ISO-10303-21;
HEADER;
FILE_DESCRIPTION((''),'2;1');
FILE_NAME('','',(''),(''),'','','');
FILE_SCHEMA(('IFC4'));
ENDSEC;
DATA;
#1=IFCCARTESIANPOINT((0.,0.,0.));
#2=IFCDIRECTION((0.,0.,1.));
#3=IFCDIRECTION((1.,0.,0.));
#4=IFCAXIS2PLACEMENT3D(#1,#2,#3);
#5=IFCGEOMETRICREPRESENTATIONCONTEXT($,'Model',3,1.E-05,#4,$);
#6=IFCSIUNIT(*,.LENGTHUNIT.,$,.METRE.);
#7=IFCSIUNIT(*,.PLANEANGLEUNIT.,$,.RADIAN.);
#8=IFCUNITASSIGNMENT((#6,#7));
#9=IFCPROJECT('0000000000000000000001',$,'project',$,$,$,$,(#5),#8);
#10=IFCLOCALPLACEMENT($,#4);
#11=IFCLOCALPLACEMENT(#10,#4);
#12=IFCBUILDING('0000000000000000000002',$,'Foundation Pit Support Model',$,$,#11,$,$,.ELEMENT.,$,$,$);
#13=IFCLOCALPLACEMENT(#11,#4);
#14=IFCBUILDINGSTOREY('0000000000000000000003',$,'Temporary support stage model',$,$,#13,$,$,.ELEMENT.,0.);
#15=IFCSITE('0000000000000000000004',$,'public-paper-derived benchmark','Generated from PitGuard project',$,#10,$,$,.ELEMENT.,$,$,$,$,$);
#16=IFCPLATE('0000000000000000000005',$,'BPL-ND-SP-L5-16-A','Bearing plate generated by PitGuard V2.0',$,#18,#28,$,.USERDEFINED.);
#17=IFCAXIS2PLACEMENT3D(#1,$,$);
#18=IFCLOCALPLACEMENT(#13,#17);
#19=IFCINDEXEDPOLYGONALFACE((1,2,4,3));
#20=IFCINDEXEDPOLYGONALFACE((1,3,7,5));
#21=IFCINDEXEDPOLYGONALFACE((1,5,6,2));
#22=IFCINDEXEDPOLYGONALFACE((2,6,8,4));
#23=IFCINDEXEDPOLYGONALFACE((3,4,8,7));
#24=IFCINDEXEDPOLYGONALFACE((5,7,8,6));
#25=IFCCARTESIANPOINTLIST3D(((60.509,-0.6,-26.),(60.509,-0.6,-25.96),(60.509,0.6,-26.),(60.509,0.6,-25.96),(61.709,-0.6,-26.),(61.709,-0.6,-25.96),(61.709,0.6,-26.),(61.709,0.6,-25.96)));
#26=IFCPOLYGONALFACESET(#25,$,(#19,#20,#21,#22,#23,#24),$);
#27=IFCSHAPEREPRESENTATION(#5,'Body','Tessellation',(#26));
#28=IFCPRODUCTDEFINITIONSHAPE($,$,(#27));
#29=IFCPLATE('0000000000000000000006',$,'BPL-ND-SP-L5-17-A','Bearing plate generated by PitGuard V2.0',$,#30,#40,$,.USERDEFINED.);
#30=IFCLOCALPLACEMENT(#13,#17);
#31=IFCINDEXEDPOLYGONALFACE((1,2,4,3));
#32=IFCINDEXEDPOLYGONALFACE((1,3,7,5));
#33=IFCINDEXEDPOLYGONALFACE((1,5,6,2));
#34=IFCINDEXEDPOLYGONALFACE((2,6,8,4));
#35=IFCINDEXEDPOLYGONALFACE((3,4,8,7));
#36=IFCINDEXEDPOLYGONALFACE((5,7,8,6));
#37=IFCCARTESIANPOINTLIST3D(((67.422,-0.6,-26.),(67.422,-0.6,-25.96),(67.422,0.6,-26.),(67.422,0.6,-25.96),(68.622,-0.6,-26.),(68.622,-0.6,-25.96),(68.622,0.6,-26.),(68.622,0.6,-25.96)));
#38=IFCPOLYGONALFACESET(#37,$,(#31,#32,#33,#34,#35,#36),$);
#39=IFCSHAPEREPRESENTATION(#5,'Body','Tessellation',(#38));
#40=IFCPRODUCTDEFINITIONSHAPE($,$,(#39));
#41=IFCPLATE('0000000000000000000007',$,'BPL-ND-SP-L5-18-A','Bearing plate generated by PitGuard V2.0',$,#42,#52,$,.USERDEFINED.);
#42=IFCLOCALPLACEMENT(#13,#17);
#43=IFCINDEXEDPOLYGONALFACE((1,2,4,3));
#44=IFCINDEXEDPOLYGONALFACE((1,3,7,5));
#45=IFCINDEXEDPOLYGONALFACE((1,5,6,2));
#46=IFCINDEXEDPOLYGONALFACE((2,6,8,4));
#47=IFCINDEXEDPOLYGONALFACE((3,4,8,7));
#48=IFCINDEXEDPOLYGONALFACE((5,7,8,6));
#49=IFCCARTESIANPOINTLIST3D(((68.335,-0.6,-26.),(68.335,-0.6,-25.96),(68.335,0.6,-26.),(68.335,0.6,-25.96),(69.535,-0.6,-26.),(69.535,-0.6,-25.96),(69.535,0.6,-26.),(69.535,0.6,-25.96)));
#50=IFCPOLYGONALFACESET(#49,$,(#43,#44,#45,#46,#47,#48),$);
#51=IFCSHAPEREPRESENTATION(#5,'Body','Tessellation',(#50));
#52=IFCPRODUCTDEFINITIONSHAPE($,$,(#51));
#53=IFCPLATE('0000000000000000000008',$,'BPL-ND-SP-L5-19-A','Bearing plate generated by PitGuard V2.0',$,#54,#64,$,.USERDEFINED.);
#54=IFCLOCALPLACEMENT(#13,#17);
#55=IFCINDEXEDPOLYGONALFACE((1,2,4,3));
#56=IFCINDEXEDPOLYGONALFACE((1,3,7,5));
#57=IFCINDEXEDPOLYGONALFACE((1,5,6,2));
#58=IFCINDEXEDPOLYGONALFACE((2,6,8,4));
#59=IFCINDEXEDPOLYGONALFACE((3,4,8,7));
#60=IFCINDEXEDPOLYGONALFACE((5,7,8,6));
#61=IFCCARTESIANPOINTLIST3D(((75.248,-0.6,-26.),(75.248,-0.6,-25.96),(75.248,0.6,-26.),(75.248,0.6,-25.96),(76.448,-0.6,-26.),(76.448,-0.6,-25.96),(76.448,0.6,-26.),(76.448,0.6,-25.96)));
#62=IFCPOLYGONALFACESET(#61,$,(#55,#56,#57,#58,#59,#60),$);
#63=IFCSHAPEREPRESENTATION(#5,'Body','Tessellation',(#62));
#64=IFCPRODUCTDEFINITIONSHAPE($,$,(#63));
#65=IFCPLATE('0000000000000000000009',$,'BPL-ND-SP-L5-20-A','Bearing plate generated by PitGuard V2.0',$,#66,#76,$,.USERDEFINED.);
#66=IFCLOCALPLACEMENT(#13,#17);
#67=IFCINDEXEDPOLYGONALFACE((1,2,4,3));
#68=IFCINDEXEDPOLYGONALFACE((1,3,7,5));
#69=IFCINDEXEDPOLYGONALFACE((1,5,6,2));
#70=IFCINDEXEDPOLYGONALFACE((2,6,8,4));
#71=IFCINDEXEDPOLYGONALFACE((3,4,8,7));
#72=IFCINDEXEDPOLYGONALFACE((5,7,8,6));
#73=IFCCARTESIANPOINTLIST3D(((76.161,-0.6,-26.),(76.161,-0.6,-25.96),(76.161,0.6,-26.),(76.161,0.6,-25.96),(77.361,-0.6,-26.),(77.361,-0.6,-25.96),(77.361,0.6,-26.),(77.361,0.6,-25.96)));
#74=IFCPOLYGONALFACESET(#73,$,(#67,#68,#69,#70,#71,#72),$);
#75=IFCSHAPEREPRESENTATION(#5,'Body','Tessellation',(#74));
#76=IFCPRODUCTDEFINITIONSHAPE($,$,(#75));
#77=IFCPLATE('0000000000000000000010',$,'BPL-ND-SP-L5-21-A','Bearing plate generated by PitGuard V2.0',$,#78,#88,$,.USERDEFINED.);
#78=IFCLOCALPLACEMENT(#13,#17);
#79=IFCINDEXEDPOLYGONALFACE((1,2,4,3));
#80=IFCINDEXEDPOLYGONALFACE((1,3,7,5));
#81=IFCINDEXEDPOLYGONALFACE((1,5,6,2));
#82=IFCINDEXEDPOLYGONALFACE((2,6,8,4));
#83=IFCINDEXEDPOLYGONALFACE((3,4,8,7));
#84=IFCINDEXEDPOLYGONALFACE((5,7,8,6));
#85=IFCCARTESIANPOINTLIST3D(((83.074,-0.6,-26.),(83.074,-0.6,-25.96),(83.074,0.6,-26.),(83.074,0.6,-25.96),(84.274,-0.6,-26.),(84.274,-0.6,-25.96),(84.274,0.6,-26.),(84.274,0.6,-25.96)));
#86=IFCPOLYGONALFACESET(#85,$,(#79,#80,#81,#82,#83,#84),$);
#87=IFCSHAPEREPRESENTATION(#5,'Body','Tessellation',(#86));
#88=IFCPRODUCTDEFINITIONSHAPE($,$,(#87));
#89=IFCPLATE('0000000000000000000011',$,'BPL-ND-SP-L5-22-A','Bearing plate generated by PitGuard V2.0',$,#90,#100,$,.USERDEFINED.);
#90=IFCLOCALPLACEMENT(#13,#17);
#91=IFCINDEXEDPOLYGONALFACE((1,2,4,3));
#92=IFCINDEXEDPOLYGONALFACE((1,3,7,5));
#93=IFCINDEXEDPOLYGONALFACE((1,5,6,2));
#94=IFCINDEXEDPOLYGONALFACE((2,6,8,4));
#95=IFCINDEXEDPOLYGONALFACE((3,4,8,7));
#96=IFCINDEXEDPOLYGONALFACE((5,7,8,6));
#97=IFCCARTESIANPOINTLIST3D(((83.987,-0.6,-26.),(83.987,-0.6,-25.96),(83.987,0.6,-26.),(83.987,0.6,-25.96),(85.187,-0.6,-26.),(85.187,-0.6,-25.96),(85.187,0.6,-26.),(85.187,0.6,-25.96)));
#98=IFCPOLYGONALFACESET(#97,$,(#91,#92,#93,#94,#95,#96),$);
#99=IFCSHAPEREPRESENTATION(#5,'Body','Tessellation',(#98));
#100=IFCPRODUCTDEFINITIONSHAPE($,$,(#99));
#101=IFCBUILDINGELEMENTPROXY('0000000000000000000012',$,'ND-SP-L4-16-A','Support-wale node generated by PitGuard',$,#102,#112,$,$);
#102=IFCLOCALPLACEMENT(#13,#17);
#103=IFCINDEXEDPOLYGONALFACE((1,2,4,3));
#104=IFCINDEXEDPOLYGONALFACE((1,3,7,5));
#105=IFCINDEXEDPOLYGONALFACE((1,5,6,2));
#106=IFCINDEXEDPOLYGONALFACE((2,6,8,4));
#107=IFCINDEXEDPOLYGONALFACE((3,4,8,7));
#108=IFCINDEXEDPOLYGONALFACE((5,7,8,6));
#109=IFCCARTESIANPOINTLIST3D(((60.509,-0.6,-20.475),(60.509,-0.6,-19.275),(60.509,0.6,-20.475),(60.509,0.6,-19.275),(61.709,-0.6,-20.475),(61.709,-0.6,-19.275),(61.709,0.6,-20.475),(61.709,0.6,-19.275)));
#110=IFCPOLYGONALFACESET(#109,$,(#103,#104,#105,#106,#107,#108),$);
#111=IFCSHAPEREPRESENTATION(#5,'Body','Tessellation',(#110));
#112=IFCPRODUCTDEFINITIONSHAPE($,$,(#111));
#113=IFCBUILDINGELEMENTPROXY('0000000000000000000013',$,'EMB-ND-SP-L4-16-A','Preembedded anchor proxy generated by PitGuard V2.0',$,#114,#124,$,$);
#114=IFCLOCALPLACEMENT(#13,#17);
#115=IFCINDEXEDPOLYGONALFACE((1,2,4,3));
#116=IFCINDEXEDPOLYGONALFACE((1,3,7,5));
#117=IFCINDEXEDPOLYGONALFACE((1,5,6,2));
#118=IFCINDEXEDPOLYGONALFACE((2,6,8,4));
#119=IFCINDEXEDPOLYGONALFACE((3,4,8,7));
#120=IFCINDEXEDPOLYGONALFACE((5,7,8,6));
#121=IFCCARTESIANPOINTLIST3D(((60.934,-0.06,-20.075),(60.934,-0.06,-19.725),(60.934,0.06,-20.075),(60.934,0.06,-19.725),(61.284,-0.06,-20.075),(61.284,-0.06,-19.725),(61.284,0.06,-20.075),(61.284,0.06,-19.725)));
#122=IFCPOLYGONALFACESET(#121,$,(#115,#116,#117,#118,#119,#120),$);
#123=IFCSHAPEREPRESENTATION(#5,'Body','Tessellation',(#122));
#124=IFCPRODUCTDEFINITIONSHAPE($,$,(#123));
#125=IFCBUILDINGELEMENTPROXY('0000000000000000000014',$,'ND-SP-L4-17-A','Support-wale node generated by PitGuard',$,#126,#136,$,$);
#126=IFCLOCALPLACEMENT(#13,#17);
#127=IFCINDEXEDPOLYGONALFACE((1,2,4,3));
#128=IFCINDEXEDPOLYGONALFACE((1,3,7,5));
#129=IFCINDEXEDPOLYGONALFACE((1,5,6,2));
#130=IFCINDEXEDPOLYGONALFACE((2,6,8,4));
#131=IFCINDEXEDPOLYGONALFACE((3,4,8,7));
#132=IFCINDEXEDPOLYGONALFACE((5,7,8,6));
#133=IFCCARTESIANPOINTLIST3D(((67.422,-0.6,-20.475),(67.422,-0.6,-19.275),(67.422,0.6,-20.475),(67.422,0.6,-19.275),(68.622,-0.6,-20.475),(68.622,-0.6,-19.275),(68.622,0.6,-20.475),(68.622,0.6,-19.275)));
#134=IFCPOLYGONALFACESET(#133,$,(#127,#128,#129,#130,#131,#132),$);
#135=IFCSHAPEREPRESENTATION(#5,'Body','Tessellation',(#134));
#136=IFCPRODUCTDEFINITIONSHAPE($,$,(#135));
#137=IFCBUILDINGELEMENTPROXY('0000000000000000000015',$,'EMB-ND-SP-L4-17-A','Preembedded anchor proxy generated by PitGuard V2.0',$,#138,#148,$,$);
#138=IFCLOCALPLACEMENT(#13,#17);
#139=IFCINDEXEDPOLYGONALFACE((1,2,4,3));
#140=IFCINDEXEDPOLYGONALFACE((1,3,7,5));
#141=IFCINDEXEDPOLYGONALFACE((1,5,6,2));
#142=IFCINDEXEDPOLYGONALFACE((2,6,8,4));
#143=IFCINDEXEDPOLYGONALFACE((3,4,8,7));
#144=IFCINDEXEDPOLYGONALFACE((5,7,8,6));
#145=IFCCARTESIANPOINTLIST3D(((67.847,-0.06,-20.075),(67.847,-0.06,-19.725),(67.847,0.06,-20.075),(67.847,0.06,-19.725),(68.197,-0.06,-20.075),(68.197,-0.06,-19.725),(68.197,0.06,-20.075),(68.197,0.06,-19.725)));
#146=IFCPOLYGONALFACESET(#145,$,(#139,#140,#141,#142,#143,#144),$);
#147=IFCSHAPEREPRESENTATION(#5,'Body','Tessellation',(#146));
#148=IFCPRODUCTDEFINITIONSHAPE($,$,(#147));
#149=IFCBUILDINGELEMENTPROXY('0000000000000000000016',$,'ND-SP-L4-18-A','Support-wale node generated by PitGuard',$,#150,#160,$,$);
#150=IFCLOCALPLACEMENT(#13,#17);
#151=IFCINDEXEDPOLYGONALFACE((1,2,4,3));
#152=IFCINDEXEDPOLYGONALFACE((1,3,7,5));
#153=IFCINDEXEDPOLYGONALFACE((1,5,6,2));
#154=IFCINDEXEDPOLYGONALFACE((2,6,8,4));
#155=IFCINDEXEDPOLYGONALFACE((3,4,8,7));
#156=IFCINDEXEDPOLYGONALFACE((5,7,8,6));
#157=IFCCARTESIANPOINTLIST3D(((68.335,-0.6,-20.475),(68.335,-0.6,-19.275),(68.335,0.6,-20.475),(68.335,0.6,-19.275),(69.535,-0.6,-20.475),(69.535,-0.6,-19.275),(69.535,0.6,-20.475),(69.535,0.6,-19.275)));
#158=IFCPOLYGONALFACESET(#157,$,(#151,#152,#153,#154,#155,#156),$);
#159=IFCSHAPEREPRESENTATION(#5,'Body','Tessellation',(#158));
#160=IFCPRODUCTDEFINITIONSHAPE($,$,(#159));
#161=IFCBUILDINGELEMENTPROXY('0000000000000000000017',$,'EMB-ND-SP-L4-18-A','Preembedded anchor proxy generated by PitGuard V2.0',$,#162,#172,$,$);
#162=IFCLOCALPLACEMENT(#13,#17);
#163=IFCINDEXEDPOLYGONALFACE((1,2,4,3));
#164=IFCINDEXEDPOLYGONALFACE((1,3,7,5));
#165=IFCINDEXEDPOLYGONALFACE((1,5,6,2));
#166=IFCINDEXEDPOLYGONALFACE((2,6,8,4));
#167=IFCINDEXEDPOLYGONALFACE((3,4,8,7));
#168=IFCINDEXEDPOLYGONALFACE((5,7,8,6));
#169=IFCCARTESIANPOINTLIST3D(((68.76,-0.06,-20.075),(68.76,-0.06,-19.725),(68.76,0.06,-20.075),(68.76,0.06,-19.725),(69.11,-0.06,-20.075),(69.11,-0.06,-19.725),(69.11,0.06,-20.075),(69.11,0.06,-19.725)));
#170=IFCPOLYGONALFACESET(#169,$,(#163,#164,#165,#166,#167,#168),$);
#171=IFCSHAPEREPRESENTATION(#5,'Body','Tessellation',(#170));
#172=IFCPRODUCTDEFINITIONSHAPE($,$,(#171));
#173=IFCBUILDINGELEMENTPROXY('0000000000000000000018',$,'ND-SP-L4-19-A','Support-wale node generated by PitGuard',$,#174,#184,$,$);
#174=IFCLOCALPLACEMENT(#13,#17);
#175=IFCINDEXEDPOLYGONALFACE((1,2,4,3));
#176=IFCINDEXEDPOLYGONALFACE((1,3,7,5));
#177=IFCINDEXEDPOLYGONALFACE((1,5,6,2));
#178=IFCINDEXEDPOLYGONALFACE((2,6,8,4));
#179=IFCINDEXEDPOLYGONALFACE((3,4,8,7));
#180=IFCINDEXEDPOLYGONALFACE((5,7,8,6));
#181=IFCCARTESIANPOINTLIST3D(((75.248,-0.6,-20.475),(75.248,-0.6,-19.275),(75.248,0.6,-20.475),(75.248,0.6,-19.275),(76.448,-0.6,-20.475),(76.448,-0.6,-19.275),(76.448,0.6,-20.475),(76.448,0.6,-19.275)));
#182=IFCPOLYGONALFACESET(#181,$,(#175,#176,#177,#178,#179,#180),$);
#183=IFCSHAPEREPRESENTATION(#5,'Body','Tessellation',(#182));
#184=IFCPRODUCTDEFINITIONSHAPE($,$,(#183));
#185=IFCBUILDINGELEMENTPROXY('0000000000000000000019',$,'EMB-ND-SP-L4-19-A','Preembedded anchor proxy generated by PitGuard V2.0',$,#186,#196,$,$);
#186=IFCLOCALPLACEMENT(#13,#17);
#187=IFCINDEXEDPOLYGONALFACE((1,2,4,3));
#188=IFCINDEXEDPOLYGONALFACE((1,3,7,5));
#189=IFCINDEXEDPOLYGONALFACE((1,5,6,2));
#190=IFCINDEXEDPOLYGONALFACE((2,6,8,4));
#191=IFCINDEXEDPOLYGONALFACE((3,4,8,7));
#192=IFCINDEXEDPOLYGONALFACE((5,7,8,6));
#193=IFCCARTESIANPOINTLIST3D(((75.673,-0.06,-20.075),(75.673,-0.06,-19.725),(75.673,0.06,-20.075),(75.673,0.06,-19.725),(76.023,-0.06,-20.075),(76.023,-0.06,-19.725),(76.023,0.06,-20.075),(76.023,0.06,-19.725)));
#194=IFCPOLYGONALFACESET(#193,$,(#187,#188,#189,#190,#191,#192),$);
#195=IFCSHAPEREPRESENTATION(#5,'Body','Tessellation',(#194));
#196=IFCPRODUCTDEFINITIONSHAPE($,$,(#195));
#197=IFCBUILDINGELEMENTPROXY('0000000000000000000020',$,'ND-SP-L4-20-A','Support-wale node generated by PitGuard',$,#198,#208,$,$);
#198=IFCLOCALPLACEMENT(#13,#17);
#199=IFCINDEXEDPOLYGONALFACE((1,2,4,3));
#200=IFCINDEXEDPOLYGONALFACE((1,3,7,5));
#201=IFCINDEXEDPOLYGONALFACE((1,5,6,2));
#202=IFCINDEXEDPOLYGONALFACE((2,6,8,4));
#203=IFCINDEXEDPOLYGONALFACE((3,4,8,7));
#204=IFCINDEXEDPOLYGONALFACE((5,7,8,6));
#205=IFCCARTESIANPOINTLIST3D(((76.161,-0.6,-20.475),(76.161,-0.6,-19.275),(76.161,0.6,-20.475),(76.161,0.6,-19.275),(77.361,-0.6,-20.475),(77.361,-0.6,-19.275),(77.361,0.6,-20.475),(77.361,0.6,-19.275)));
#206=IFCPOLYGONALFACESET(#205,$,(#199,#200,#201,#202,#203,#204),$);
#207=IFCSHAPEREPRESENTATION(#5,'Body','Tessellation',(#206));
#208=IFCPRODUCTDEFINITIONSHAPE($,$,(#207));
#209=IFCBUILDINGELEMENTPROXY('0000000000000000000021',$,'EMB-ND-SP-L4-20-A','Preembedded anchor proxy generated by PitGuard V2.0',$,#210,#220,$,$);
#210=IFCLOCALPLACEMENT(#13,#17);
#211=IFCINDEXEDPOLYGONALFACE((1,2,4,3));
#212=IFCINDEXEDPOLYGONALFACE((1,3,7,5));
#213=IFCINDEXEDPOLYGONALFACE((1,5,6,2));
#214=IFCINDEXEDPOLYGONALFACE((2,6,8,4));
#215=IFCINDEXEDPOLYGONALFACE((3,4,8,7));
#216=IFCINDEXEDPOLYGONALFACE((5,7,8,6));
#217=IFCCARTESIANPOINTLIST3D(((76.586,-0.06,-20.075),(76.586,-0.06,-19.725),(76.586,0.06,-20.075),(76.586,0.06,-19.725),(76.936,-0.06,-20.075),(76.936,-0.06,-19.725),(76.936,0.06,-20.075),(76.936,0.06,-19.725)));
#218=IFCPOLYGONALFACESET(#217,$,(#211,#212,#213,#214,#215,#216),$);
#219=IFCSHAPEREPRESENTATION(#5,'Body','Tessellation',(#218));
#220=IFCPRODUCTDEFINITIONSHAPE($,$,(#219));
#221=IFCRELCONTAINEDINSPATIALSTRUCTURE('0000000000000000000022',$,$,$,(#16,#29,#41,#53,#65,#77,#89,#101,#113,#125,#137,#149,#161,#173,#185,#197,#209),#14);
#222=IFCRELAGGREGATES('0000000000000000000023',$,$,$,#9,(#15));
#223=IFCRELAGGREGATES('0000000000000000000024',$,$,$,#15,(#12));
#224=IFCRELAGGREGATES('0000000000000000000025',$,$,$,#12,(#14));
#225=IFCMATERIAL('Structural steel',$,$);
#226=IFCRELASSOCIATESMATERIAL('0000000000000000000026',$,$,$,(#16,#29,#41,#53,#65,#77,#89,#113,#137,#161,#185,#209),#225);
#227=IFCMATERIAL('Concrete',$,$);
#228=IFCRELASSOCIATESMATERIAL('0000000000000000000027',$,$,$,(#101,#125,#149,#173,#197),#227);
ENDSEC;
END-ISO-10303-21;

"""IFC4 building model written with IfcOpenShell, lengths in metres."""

from ifc_helpers import new_model, si_unit, frame, origin_with_axes, origin_2d, place, context, project, spatial, rectangle, extrude, material, element, save


model = new_model("IFC4")

# Units and contexts
model_context = context("Model", 3, precision=1e-05, world=origin_with_axes())
ifc_project = project(units=[si_unit("LENGTHUNIT", "METRE"), si_unit("PLANEANGLEUNIT", "RADIAN")], contexts=[model_context])

# Site, building, storey
site_placement = place(None, origin_with_axes())
site = spatial("IfcSite", under=ifc_project, at=site_placement, Name="public-paper-derived benchmark", Description="Generated from PitGuard project", CompositionType="ELEMENT")
building_placement = place(site_placement, origin_with_axes())
building = spatial("IfcBuilding", under=site, at=building_placement, Name="Foundation Pit Support Model", CompositionType="ELEMENT")
storey_placement = place(building_placement, origin_with_axes())
storey = spatial("IfcBuildingStorey", under=building, at=storey_placement, Name="Temporary support stage model", CompositionType="ELEMENT", Elevation=0.0)

# Plates
ifc_material_1 = material(Name="Structural steel")
for number, where, z_axis, x_axis, name in (
    (1, (61.109, 0.0, -26.0), (0.0, 0.0, 1.0), (1.0, 0.0, 0.0), "BPL-ND-SP-L5-16-A"),
    (2, (68.022, 0.0, -26.0), (0.0, 0.0, 1.0), (1.0, 0.0, 0.0), "BPL-ND-SP-L5-17-A"),
    (3, (68.935, 0.0, -26.0), (0.0, 0.0, 1.0), (1.0, 0.0, 0.0), "BPL-ND-SP-L5-18-A"),
    (4, (75.848, 0.0, -26.0), (0.0, 0.0, 1.0), (1.0, 0.0, 0.0), "BPL-ND-SP-L5-19-A"),
    (5, (76.761, 0.0, -26.0), (0.0, 0.0, 1.0), (1.0, 0.0, 0.0), "BPL-ND-SP-L5-20-A"),
    (6, (83.674, 0.0, -26.0), (0.0, 0.0, 1.0), (1.0, 0.0, 0.0), "BPL-ND-SP-L5-21-A"),
    (7, (84.587, 0.0, -26.0), (0.0, 0.0, 1.0), (1.0, 0.0, 0.0), "BPL-ND-SP-L5-22-A"),
):
    element("IfcPlate", number, at=place(storey_placement, frame(where, z_axis=z_axis, x_axis=x_axis)), inside=storey, material=ifc_material_1, Name=name, Description="Bearing plate generated by PitGuard V2.0", PredefinedType="USERDEFINED", context=model_context, shape_type="SweptSolid", body=[
        extrude(rectangle(XDim=1.2, YDim=1.2, at=origin_2d()), origin_with_axes(), (0.0, 0.0, 1.0), 0.04),
    ])

# Building element proxies
ifc_material_2 = material(Name="Concrete")
proxy_1_placement = place(storey_placement, frame((61.109, 0.0, -20.475), z_axis=(0.0, 0.0, 1.0), x_axis=(1.0, 0.0, 0.0)))
element("IfcBuildingElementProxy", 8, at=proxy_1_placement, inside=storey, material=ifc_material_2, Name="ND-SP-L4-16-A", Description="Support-wale node generated by PitGuard", context=model_context, shape_type="SweptSolid", body=[
    extrude(rectangle(XDim=1.2, YDim=1.2, at=origin_2d()), origin_with_axes(), (0.0, 0.0, 1.0), 1.2),
])
proxy_2_placement = place(storey_placement, frame((61.109, 0.0, -20.075), z_axis=(0.0, 0.0, 1.0), x_axis=(1.0, 0.0, 0.0)))
element("IfcBuildingElementProxy", 9, at=proxy_2_placement, inside=storey, material=ifc_material_1, Name="EMB-ND-SP-L4-16-A", Description="Preembedded anchor proxy generated by PitGuard V2.0", context=model_context, shape_type="SweptSolid", body=[
    extrude(rectangle(XDim=0.35, YDim=0.12, at=origin_2d()), origin_with_axes(), (0.0, 0.0, 1.0), 0.35),
])
proxy_3_placement = place(storey_placement, frame((68.022, 0.0, -20.475), z_axis=(0.0, 0.0, 1.0), x_axis=(1.0, 0.0, 0.0)))
element("IfcBuildingElementProxy", 10, at=proxy_3_placement, inside=storey, material=ifc_material_2, Name="ND-SP-L4-17-A", Description="Support-wale node generated by PitGuard", context=model_context, shape_type="SweptSolid", body=[
    extrude(rectangle(XDim=1.2, YDim=1.2, at=origin_2d()), origin_with_axes(), (0.0, 0.0, 1.0), 1.2),
])
proxy_4_placement = place(storey_placement, frame((68.022, 0.0, -20.075), z_axis=(0.0, 0.0, 1.0), x_axis=(1.0, 0.0, 0.0)))
element("IfcBuildingElementProxy", 11, at=proxy_4_placement, inside=storey, material=ifc_material_1, Name="EMB-ND-SP-L4-17-A", Description="Preembedded anchor proxy generated by PitGuard V2.0", context=model_context, shape_type="SweptSolid", body=[
    extrude(rectangle(XDim=0.35, YDim=0.12, at=origin_2d()), origin_with_axes(), (0.0, 0.0, 1.0), 0.35),
])
proxy_5_placement = place(storey_placement, frame((68.935, 0.0, -20.475), z_axis=(0.0, 0.0, 1.0), x_axis=(1.0, 0.0, 0.0)))
element("IfcBuildingElementProxy", 12, at=proxy_5_placement, inside=storey, material=ifc_material_2, Name="ND-SP-L4-18-A", Description="Support-wale node generated by PitGuard", context=model_context, shape_type="SweptSolid", body=[
    extrude(rectangle(XDim=1.2, YDim=1.2, at=origin_2d()), origin_with_axes(), (0.0, 0.0, 1.0), 1.2),
])
proxy_6_placement = place(storey_placement, frame((68.935, 0.0, -20.075), z_axis=(0.0, 0.0, 1.0), x_axis=(1.0, 0.0, 0.0)))
element("IfcBuildingElementProxy", 13, at=proxy_6_placement, inside=storey, material=ifc_material_1, Name="EMB-ND-SP-L4-18-A", Description="Preembedded anchor proxy generated by PitGuard V2.0", context=model_context, shape_type="SweptSolid", body=[
    extrude(rectangle(XDim=0.35, YDim=0.12, at=origin_2d()), origin_with_axes(), (0.0, 0.0, 1.0), 0.35),
])
proxy_7_placement = place(storey_placement, frame((75.848, 0.0, -20.475), z_axis=(0.0, 0.0, 1.0), x_axis=(1.0, 0.0, 0.0)))
element("IfcBuildingElementProxy", 14, at=proxy_7_placement, inside=storey, material=ifc_material_2, Name="ND-SP-L4-19-A", Description="Support-wale node generated by PitGuard", context=model_context, shape_type="SweptSolid", body=[
    extrude(rectangle(XDim=1.2, YDim=1.2, at=origin_2d()), origin_with_axes(), (0.0, 0.0, 1.0), 1.2),
])
proxy_8_placement = place(storey_placement, frame((75.848, 0.0, -20.075), z_axis=(0.0, 0.0, 1.0), x_axis=(1.0, 0.0, 0.0)))
element("IfcBuildingElementProxy", 15, at=proxy_8_placement, inside=storey, material=ifc_material_1, Name="EMB-ND-SP-L4-19-A", Description="Preembedded anchor proxy generated by PitGuard V2.0", context=model_context, shape_type="SweptSolid", body=[
    extrude(rectangle(XDim=0.35, YDim=0.12, at=origin_2d()), origin_with_axes(), (0.0, 0.0, 1.0), 0.35),
])
proxy_9_placement = place(storey_placement, frame((76.761, 0.0, -20.475), z_axis=(0.0, 0.0, 1.0), x_axis=(1.0, 0.0, 0.0)))
element("IfcBuildingElementProxy", 16, at=proxy_9_placement, inside=storey, material=ifc_material_2, Name="ND-SP-L4-20-A", Description="Support-wale node generated by PitGuard", context=model_context, shape_type="SweptSolid", body=[
    extrude(rectangle(XDim=1.2, YDim=1.2, at=origin_2d()), origin_with_axes(), (0.0, 0.0, 1.0), 1.2),
])
proxy_10_placement = place(storey_placement, frame((76.761, 0.0, -20.075), z_axis=(0.0, 0.0, 1.0), x_axis=(1.0, 0.0, 0.0)))
element("IfcBuildingElementProxy", 17, at=proxy_10_placement, inside=storey, material=ifc_material_1, Name="EMB-ND-SP-L4-20-A", Description="Preembedded anchor proxy generated by PitGuard V2.0", context=model_context, shape_type="SweptSolid", body=[
    extrude(rectangle(XDim=0.35, YDim=0.12, at=origin_2d()), origin_with_axes(), (0.0, 0.0, 1.0), 0.35),
])

save(model, "model.ifc")
